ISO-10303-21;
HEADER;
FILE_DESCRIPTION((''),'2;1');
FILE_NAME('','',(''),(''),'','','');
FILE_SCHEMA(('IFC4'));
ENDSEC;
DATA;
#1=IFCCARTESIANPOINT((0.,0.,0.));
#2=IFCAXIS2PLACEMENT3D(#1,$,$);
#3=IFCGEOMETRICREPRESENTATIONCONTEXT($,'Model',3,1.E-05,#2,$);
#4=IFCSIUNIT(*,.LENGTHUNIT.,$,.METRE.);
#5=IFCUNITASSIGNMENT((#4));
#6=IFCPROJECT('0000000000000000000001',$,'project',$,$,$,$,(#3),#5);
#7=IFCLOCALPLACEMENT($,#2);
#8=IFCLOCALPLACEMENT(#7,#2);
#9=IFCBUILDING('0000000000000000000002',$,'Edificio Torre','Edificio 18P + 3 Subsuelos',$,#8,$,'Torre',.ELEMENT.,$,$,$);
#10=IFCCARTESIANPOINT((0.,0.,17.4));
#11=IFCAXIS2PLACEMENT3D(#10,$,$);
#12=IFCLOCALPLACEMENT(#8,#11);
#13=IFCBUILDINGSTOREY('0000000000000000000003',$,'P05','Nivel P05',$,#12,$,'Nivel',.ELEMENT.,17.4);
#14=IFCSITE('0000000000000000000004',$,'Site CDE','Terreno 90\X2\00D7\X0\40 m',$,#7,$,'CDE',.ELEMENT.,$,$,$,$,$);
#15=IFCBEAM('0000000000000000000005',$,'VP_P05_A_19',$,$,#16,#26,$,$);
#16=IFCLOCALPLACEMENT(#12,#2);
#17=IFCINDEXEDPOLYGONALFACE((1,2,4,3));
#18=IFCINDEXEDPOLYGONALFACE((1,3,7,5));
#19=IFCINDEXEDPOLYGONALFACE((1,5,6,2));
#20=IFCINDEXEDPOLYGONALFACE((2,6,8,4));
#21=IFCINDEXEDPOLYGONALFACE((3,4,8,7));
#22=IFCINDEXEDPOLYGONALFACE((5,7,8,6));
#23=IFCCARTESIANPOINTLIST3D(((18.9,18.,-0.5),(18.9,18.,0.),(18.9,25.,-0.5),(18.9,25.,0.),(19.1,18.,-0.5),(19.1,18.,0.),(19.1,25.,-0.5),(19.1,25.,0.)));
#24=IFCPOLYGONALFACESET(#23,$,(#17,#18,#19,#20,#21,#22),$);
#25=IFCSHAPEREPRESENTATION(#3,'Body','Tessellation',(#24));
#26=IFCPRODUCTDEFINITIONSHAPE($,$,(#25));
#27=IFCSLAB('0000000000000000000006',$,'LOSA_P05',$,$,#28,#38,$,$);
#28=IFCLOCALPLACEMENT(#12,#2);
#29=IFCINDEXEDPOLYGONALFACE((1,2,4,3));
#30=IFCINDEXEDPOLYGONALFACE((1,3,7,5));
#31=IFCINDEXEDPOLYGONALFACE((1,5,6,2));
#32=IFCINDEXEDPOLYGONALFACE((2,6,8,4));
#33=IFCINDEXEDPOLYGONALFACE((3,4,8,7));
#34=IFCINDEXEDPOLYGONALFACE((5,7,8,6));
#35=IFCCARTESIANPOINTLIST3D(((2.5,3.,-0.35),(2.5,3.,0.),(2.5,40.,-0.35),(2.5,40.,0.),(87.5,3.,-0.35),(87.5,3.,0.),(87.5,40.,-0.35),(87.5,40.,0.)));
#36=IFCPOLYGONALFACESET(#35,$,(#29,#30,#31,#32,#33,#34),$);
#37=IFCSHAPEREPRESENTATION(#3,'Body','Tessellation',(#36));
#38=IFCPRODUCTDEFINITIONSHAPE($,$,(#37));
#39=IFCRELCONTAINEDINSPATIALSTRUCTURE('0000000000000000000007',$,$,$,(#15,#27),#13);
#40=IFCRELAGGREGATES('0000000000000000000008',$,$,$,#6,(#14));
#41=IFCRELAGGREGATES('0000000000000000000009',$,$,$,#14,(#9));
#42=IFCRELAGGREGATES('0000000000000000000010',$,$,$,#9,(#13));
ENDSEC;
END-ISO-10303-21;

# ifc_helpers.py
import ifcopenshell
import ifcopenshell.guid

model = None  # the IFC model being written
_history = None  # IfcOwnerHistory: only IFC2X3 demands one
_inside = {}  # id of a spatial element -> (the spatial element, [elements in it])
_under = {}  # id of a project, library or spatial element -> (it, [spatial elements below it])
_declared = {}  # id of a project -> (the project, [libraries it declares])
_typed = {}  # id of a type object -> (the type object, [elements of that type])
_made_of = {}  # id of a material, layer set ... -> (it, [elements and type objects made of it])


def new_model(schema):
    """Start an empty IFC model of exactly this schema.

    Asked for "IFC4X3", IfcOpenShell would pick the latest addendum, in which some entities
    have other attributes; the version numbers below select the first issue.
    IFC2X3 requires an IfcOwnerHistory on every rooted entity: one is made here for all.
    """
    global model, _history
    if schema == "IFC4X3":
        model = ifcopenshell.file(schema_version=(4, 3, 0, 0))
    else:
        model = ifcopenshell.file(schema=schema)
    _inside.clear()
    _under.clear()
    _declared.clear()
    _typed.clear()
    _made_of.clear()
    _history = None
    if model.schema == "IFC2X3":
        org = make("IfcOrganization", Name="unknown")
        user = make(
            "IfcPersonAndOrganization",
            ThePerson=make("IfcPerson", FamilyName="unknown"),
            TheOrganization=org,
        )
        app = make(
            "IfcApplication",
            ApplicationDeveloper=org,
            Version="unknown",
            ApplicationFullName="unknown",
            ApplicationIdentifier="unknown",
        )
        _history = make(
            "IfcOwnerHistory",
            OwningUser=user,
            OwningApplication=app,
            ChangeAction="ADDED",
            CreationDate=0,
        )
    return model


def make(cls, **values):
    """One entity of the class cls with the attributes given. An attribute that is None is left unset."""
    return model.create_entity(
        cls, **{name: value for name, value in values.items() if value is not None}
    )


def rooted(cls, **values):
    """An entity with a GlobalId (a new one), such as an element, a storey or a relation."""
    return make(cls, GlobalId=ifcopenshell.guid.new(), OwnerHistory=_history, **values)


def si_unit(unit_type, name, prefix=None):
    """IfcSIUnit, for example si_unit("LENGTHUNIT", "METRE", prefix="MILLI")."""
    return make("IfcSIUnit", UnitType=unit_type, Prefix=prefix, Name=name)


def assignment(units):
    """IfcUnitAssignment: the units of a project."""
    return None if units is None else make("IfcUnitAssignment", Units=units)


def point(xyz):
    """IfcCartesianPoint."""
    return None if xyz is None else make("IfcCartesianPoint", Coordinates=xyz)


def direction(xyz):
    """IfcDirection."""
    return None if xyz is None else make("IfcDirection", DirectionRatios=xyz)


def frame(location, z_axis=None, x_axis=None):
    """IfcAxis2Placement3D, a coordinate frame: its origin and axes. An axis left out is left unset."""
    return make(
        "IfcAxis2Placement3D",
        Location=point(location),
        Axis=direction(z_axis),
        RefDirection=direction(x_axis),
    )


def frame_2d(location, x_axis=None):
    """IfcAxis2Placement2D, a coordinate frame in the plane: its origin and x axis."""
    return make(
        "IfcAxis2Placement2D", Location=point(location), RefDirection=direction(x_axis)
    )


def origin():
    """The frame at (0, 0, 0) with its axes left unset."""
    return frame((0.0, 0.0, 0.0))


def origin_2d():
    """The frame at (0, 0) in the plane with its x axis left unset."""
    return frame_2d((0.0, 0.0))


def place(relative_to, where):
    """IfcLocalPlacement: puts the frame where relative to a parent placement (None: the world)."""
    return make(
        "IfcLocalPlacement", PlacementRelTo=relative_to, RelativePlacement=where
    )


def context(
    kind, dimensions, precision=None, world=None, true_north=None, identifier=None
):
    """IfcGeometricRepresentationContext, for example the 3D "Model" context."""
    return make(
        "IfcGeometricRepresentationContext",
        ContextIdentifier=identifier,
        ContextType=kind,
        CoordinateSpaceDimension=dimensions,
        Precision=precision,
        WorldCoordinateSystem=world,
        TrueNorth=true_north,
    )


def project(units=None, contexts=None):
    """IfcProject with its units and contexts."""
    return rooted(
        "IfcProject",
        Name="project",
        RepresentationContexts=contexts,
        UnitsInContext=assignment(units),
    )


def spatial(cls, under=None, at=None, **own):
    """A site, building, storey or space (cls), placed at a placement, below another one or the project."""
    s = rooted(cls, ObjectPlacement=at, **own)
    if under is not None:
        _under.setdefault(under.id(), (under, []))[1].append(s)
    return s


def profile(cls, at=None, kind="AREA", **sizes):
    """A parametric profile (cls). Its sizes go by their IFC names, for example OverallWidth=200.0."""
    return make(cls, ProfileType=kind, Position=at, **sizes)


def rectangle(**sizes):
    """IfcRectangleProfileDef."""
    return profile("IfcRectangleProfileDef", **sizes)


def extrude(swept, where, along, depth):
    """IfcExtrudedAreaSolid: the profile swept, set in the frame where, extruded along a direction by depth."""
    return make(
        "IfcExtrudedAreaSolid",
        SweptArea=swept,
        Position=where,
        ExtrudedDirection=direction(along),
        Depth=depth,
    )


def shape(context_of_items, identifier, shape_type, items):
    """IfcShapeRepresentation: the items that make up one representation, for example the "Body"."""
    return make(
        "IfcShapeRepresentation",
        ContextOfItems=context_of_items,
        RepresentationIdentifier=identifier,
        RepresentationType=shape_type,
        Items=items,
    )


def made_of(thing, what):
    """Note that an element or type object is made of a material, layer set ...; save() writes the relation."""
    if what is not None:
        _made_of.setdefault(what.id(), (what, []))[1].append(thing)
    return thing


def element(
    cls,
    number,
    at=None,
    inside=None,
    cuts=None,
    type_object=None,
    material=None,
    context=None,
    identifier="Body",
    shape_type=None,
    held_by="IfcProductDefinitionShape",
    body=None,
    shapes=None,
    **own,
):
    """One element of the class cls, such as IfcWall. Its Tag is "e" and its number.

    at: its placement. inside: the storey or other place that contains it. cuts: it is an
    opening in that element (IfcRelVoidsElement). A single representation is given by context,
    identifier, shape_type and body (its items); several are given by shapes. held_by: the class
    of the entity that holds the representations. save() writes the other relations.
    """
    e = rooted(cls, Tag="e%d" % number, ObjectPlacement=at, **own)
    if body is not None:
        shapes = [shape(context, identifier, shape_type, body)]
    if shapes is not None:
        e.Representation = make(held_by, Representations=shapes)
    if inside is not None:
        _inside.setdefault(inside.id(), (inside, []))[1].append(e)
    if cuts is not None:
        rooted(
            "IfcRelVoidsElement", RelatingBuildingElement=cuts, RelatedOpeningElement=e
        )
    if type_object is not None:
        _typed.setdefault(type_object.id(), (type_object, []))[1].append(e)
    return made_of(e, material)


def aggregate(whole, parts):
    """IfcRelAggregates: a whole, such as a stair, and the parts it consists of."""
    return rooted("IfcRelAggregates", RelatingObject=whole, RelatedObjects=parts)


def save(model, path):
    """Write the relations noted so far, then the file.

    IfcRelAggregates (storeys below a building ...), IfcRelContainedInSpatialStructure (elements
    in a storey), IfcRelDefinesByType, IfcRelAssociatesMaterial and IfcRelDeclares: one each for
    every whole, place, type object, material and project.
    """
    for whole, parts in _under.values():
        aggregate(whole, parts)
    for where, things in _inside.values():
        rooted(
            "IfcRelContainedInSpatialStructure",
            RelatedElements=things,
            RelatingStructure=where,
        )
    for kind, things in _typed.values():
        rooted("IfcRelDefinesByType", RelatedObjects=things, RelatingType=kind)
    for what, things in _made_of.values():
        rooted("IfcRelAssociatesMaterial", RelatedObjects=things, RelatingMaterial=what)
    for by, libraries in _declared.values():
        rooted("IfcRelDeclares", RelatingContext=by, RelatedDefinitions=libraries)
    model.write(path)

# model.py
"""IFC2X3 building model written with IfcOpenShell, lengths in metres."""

from ifc_helpers import new_model, si_unit, frame, origin, origin_2d, place, context, project, spatial, rectangle, extrude, element, save


model = new_model("IFC2X3")

# Units and contexts
model_context = context("Model", 3, precision=1e-05, world=origin())
ifc_project = project(units=[si_unit("LENGTHUNIT", "METRE")], contexts=[model_context])

# Site, building, storey
site_placement = place(None, origin())
site = spatial("IfcSite", under=ifc_project, at=site_placement, Name="Site CDE", Description="Terreno 90×40 m", LongName="CDE", CompositionType="ELEMENT")
building_placement = place(site_placement, origin())
building = spatial("IfcBuilding", under=site, at=building_placement, Name="Edificio Torre", Description="Edificio 18P + 3 Subsuelos", LongName="Torre", CompositionType="ELEMENT")
storey_placement = place(building_placement, frame((0.0, 0.0, 17.4)))
storey = spatial("IfcBuildingStorey", under=building, at=storey_placement, Name="P05", Description="Nivel P05", LongName="Nivel", CompositionType="ELEMENT", Elevation=17.4)

# Beam
beam_1_placement = place(storey_placement, frame((19.0, 21.5, -0.5)))
element("IfcBeam", 1, at=beam_1_placement, inside=storey, Name="VP_P05_A_19", context=model_context, shape_type="SweptSolid", body=[
    extrude(rectangle(XDim=0.2, YDim=7.0, at=origin_2d()), origin(), (0.0, 0.0, 1.0), 0.5),
])

# Slab
slab_placement = place(storey_placement, frame((45.0, 21.5, -0.35)))
element("IfcSlab", 2, at=slab_placement, inside=storey, Name="LOSA_P05", context=model_context, shape_type="SweptSolid", body=[
    extrude(rectangle(XDim=85.0, YDim=37.0, at=origin_2d()), origin(), (0.0, 0.0, 1.0), 0.35),
])

save(model, "model.ifc")
